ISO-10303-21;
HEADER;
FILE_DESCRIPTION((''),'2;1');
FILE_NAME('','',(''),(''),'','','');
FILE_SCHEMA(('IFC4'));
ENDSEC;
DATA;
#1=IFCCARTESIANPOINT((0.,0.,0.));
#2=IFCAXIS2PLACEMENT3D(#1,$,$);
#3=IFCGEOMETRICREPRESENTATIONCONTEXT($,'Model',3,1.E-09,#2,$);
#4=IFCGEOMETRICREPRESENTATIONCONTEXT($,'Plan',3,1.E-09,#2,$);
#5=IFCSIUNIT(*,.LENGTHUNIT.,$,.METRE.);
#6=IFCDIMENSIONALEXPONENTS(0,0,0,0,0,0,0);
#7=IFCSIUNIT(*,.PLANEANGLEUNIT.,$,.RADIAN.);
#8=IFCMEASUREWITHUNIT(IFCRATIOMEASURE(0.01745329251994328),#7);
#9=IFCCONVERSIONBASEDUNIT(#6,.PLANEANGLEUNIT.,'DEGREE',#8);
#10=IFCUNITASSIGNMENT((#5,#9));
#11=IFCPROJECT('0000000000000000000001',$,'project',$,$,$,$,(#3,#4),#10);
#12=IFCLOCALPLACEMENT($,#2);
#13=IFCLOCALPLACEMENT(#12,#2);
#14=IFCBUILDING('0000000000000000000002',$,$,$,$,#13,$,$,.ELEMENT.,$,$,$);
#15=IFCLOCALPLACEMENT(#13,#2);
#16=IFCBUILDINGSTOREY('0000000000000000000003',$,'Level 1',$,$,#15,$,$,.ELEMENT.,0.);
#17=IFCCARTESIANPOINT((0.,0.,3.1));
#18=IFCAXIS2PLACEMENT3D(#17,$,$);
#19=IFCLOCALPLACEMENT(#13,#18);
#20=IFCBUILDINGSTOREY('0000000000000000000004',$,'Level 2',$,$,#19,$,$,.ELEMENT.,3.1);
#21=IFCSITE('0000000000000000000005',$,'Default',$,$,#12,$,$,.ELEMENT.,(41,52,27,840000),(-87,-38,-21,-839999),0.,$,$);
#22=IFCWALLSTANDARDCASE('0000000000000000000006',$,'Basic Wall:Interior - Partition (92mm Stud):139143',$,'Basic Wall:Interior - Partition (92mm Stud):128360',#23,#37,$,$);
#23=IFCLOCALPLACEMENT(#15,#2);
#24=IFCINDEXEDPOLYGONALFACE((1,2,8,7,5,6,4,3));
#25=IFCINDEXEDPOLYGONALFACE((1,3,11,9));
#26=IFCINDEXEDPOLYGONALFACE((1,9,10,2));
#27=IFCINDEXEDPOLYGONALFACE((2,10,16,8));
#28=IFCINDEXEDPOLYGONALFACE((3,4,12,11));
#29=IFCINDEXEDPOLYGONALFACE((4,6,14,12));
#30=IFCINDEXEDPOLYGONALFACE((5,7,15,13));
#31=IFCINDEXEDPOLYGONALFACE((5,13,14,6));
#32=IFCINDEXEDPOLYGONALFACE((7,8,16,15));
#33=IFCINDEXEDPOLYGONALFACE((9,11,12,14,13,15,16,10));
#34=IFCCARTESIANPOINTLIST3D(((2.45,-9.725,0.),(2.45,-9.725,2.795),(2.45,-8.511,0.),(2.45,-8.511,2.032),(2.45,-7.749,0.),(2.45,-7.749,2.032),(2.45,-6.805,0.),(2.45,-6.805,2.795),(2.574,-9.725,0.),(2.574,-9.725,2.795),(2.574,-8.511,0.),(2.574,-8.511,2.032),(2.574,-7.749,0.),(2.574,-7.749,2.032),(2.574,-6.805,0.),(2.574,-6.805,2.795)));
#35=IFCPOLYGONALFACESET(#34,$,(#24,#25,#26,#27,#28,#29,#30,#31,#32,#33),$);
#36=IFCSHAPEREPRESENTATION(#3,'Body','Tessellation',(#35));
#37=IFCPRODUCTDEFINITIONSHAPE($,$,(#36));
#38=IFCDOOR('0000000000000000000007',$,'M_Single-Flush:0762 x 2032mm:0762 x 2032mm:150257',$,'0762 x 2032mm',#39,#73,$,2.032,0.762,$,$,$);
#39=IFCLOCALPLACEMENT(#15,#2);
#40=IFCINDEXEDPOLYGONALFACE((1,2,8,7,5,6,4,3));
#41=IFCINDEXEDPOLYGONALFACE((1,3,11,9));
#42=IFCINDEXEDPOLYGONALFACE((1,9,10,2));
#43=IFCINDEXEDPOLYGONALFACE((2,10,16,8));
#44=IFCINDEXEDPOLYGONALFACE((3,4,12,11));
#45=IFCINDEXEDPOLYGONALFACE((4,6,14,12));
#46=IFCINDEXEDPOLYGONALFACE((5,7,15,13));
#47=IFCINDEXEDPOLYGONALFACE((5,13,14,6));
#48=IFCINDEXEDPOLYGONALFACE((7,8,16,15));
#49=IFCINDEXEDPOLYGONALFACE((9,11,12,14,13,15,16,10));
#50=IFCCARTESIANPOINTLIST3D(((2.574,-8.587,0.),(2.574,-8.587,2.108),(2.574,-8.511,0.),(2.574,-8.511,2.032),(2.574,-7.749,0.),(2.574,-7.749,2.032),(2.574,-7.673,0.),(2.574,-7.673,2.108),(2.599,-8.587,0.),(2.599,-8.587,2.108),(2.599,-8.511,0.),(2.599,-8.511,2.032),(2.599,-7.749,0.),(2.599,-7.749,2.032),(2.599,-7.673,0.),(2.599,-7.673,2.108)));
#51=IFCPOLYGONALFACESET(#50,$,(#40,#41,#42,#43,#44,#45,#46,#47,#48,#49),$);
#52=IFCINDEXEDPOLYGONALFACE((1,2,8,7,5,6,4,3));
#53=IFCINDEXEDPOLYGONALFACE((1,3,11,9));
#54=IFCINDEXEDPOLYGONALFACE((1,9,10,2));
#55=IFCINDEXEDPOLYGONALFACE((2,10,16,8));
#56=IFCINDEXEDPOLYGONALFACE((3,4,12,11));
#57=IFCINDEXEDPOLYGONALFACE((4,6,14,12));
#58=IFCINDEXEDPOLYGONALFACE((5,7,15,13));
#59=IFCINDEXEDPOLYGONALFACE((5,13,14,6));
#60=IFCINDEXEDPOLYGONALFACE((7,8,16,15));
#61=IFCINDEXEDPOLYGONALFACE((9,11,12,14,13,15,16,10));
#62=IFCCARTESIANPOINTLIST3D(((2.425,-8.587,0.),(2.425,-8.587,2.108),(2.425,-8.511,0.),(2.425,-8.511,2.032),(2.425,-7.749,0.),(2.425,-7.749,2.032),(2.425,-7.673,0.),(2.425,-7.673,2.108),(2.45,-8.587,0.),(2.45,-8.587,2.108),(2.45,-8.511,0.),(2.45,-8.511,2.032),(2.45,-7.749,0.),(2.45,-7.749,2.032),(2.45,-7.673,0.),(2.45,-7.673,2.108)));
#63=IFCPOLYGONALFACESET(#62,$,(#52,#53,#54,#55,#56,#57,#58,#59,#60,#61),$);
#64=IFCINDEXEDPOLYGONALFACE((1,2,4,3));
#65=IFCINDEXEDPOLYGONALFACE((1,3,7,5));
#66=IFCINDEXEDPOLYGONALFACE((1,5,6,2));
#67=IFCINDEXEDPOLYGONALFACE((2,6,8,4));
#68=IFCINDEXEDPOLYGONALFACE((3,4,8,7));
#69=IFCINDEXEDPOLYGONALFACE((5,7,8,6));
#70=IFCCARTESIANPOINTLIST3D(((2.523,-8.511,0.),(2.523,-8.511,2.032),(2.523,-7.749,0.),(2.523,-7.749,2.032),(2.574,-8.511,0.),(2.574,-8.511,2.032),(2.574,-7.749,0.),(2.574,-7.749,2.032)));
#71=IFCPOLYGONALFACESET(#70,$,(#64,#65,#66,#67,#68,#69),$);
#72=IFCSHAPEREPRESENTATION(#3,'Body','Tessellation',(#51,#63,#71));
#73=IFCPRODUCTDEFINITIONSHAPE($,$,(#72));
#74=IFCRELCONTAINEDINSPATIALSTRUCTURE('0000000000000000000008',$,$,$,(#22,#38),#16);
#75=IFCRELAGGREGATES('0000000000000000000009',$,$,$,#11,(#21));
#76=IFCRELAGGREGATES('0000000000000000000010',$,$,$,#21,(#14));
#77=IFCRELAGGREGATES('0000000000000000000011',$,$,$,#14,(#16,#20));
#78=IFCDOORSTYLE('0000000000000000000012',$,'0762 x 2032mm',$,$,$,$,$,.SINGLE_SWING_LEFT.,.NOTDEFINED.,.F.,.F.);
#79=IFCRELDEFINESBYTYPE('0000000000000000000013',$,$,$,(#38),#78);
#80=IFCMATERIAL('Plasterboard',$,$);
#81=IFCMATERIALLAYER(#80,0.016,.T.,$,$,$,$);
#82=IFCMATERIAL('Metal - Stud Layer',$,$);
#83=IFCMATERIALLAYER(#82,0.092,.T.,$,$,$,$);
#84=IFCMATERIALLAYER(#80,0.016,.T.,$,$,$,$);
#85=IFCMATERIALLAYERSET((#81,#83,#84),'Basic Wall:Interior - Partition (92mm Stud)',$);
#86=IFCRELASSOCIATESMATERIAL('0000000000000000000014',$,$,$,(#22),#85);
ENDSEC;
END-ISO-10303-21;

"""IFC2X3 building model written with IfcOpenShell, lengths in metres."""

from ifc_helpers import new_model, entity, si_unit, converted_unit, frame, frame_2d, origin, origin_2d_with_axis, place, context, project, spatial, polyline, rectangle, outline, extrude, source, transform, mapped, material, layer, layer_set, layer_usage, type_object, type_shapes, element, fill, save


model = new_model("IFC2X3")

# Units and contexts
model_context = context("Model", 3, precision=1e-09, world=origin())
plan_context = context("Plan", 3, precision=1e-09, world=origin())
ifc_project = project(units=[si_unit("LENGTHUNIT", "METRE"), converted_unit("PLANEANGLEUNIT", "DEGREE", entity("IfcRatioMeasure", 0.01745329251994328), si_unit("PLANEANGLEUNIT", "RADIAN"), dimensions=[0, 0, 0, 0, 0, 0, 0])], contexts=[model_context, plan_context])

# Site, building, storey
site_placement = place(None, origin())
site = spatial("IfcSite", under=ifc_project, at=site_placement, Name="Default", CompositionType="ELEMENT", RefLatitude=(41, 52, 27, 840000), RefLongitude=(-87, -38, -21, -839999), RefElevation=0.0)
building_placement = place(site_placement, origin())
building = spatial("IfcBuilding", under=site, at=building_placement, CompositionType="ELEMENT")
storey_1_placement = place(building_placement, origin())
storey_1 = spatial("IfcBuildingStorey", under=building, at=storey_1_placement, Name="Level 1", CompositionType="ELEMENT", Elevation=0.0)

# Shared definitions
ifc_material_1 = material(Name="Metal - Stud Layer")
ifc_material_2 = material(Name="Plasterboard")

# Wall, opening, door
ifc_layer_1 = layer(ifc_material_2, 0.016, ventilated=True)
ifc_layer_2 = layer(ifc_material_1, 0.092, ventilated=True)
ifc_layer_3 = layer(ifc_material_2, 0.016, ventilated=True)
ifc_layer_set_1 = layer_set([ifc_layer_1, ifc_layer_2, ifc_layer_3], Name="Basic Wall:Interior - Partition (92mm Stud)")
ifc_layer_usage_1 = layer_usage(ifc_layer_set_1, "AXIS2", "NEGATIVE", 0.062)
wall_1_placement = place(storey_1_placement, frame((2.512, -6.805, 0.0), z_axis=(0.0, 0.0, 1.0), x_axis=(0.0, -1.0, 0.0)))
wall_1 = element("IfcWallStandardCase", 1, at=wall_1_placement, inside=storey_1, material=ifc_layer_usage_1, Name="Basic Wall:Interior - Partition (92mm Stud):139143", ObjectType="Basic Wall:Interior - Partition (92mm Stud):128360", context=model_context, shape_type="SweptSolid", body=[
    extrude(rectangle(XDim=2.92, YDim=0.124, at=frame_2d((1.46, 0.0), x_axis=(-1.0, 0.0))), origin(), (0.0, 0.0, 1.0), 2.795),
])
opening_1_placement = place(wall_1_placement, frame((0.944, -0.062, 0.0)))
opening_1 = element("IfcOpeningElement", 2, at=opening_1_placement, cuts=wall_1, ObjectType="Opening", context=model_context, shape_type="SweptSolid", body=[
    extrude(rectangle(XDim=0.762, YDim=2.032, at=frame_2d((1.016, 0.381), x_axis=(0.0, -1.0))), frame((0.0, 0.0, 0.0), z_axis=(0.0, 1.0, 0.0), x_axis=(0.0, 0.0, 1.0)), (0.0, 0.0, 1.0), 0.124),
])
door_style_1 = type_object("IfcDoorStyle", Name="0762 x 2032mm", ConstructionType="NOTDEFINED", OperationType="SINGLE_SWING_LEFT", ParameterTakesPrecedence=False, Sizeable=False)
shared_shape_1 = source(origin(), model_context, "Body", "SweptSolid", [
    extrude(outline(polyline([(-0.457, -1.073), (0.457, -1.073), (0.457, 1.035), (0.381, 1.035), (0.381, -0.997), (-0.381, -0.997), (-0.381, 1.035), (-0.457, 1.035), (-0.457, -1.073)])), frame((0.381, 0.149, 1.035), z_axis=(0.0, -1.0, 0.0), x_axis=(-1.0, 0.0, 0.0)), (0.0, 0.0, 1.0), 0.025),
    extrude(outline(polyline([(-1.073, -0.457), (1.035, -0.457), (1.035, -0.381), (-0.997, -0.381), (-0.997, 0.381), (1.035, 0.381), (1.035, 0.457), (-1.073, 0.457), (-1.073, -0.457)])), frame((0.381, 0.0, 1.035), z_axis=(0.0, -1.0, 0.0), x_axis=(0.0, 0.0, -1.0)), (0.0, 0.0, 1.0), 0.025),
    extrude(rectangle(XDim=0.762, YDim=0.051, at=origin_2d_with_axis()), frame((0.381, 0.0985, 0.0)), (0.0, 0.0, 1.0), 2.032),
])
type_shapes(door_style_1, [shared_shape_1])
door_1_placement = place(opening_1_placement, origin())
door_1 = element("IfcDoor", 3, at=door_1_placement, inside=storey_1, type_object=door_style_1, Name="M_Single-Flush:0762 x 2032mm:0762 x 2032mm:150257", ObjectType="0762 x 2032mm", OverallHeight=2.032, OverallWidth=0.762, context=model_context, shape_type="MappedRepresentation", body=[
    mapped(shared_shape_1, transform((0.0, 0.0, 0.0), scale=1.0)),
])
fill(opening_1, door_1)

# Shared definitions
storey_2_placement = place(building_placement, frame((0.0, 0.0, 3.1)))
storey_2 = spatial("IfcBuildingStorey", under=building, at=storey_2_placement, Name="Level 2", CompositionType="ELEMENT", Elevation=3.1)

save(model, "model.ifc")
